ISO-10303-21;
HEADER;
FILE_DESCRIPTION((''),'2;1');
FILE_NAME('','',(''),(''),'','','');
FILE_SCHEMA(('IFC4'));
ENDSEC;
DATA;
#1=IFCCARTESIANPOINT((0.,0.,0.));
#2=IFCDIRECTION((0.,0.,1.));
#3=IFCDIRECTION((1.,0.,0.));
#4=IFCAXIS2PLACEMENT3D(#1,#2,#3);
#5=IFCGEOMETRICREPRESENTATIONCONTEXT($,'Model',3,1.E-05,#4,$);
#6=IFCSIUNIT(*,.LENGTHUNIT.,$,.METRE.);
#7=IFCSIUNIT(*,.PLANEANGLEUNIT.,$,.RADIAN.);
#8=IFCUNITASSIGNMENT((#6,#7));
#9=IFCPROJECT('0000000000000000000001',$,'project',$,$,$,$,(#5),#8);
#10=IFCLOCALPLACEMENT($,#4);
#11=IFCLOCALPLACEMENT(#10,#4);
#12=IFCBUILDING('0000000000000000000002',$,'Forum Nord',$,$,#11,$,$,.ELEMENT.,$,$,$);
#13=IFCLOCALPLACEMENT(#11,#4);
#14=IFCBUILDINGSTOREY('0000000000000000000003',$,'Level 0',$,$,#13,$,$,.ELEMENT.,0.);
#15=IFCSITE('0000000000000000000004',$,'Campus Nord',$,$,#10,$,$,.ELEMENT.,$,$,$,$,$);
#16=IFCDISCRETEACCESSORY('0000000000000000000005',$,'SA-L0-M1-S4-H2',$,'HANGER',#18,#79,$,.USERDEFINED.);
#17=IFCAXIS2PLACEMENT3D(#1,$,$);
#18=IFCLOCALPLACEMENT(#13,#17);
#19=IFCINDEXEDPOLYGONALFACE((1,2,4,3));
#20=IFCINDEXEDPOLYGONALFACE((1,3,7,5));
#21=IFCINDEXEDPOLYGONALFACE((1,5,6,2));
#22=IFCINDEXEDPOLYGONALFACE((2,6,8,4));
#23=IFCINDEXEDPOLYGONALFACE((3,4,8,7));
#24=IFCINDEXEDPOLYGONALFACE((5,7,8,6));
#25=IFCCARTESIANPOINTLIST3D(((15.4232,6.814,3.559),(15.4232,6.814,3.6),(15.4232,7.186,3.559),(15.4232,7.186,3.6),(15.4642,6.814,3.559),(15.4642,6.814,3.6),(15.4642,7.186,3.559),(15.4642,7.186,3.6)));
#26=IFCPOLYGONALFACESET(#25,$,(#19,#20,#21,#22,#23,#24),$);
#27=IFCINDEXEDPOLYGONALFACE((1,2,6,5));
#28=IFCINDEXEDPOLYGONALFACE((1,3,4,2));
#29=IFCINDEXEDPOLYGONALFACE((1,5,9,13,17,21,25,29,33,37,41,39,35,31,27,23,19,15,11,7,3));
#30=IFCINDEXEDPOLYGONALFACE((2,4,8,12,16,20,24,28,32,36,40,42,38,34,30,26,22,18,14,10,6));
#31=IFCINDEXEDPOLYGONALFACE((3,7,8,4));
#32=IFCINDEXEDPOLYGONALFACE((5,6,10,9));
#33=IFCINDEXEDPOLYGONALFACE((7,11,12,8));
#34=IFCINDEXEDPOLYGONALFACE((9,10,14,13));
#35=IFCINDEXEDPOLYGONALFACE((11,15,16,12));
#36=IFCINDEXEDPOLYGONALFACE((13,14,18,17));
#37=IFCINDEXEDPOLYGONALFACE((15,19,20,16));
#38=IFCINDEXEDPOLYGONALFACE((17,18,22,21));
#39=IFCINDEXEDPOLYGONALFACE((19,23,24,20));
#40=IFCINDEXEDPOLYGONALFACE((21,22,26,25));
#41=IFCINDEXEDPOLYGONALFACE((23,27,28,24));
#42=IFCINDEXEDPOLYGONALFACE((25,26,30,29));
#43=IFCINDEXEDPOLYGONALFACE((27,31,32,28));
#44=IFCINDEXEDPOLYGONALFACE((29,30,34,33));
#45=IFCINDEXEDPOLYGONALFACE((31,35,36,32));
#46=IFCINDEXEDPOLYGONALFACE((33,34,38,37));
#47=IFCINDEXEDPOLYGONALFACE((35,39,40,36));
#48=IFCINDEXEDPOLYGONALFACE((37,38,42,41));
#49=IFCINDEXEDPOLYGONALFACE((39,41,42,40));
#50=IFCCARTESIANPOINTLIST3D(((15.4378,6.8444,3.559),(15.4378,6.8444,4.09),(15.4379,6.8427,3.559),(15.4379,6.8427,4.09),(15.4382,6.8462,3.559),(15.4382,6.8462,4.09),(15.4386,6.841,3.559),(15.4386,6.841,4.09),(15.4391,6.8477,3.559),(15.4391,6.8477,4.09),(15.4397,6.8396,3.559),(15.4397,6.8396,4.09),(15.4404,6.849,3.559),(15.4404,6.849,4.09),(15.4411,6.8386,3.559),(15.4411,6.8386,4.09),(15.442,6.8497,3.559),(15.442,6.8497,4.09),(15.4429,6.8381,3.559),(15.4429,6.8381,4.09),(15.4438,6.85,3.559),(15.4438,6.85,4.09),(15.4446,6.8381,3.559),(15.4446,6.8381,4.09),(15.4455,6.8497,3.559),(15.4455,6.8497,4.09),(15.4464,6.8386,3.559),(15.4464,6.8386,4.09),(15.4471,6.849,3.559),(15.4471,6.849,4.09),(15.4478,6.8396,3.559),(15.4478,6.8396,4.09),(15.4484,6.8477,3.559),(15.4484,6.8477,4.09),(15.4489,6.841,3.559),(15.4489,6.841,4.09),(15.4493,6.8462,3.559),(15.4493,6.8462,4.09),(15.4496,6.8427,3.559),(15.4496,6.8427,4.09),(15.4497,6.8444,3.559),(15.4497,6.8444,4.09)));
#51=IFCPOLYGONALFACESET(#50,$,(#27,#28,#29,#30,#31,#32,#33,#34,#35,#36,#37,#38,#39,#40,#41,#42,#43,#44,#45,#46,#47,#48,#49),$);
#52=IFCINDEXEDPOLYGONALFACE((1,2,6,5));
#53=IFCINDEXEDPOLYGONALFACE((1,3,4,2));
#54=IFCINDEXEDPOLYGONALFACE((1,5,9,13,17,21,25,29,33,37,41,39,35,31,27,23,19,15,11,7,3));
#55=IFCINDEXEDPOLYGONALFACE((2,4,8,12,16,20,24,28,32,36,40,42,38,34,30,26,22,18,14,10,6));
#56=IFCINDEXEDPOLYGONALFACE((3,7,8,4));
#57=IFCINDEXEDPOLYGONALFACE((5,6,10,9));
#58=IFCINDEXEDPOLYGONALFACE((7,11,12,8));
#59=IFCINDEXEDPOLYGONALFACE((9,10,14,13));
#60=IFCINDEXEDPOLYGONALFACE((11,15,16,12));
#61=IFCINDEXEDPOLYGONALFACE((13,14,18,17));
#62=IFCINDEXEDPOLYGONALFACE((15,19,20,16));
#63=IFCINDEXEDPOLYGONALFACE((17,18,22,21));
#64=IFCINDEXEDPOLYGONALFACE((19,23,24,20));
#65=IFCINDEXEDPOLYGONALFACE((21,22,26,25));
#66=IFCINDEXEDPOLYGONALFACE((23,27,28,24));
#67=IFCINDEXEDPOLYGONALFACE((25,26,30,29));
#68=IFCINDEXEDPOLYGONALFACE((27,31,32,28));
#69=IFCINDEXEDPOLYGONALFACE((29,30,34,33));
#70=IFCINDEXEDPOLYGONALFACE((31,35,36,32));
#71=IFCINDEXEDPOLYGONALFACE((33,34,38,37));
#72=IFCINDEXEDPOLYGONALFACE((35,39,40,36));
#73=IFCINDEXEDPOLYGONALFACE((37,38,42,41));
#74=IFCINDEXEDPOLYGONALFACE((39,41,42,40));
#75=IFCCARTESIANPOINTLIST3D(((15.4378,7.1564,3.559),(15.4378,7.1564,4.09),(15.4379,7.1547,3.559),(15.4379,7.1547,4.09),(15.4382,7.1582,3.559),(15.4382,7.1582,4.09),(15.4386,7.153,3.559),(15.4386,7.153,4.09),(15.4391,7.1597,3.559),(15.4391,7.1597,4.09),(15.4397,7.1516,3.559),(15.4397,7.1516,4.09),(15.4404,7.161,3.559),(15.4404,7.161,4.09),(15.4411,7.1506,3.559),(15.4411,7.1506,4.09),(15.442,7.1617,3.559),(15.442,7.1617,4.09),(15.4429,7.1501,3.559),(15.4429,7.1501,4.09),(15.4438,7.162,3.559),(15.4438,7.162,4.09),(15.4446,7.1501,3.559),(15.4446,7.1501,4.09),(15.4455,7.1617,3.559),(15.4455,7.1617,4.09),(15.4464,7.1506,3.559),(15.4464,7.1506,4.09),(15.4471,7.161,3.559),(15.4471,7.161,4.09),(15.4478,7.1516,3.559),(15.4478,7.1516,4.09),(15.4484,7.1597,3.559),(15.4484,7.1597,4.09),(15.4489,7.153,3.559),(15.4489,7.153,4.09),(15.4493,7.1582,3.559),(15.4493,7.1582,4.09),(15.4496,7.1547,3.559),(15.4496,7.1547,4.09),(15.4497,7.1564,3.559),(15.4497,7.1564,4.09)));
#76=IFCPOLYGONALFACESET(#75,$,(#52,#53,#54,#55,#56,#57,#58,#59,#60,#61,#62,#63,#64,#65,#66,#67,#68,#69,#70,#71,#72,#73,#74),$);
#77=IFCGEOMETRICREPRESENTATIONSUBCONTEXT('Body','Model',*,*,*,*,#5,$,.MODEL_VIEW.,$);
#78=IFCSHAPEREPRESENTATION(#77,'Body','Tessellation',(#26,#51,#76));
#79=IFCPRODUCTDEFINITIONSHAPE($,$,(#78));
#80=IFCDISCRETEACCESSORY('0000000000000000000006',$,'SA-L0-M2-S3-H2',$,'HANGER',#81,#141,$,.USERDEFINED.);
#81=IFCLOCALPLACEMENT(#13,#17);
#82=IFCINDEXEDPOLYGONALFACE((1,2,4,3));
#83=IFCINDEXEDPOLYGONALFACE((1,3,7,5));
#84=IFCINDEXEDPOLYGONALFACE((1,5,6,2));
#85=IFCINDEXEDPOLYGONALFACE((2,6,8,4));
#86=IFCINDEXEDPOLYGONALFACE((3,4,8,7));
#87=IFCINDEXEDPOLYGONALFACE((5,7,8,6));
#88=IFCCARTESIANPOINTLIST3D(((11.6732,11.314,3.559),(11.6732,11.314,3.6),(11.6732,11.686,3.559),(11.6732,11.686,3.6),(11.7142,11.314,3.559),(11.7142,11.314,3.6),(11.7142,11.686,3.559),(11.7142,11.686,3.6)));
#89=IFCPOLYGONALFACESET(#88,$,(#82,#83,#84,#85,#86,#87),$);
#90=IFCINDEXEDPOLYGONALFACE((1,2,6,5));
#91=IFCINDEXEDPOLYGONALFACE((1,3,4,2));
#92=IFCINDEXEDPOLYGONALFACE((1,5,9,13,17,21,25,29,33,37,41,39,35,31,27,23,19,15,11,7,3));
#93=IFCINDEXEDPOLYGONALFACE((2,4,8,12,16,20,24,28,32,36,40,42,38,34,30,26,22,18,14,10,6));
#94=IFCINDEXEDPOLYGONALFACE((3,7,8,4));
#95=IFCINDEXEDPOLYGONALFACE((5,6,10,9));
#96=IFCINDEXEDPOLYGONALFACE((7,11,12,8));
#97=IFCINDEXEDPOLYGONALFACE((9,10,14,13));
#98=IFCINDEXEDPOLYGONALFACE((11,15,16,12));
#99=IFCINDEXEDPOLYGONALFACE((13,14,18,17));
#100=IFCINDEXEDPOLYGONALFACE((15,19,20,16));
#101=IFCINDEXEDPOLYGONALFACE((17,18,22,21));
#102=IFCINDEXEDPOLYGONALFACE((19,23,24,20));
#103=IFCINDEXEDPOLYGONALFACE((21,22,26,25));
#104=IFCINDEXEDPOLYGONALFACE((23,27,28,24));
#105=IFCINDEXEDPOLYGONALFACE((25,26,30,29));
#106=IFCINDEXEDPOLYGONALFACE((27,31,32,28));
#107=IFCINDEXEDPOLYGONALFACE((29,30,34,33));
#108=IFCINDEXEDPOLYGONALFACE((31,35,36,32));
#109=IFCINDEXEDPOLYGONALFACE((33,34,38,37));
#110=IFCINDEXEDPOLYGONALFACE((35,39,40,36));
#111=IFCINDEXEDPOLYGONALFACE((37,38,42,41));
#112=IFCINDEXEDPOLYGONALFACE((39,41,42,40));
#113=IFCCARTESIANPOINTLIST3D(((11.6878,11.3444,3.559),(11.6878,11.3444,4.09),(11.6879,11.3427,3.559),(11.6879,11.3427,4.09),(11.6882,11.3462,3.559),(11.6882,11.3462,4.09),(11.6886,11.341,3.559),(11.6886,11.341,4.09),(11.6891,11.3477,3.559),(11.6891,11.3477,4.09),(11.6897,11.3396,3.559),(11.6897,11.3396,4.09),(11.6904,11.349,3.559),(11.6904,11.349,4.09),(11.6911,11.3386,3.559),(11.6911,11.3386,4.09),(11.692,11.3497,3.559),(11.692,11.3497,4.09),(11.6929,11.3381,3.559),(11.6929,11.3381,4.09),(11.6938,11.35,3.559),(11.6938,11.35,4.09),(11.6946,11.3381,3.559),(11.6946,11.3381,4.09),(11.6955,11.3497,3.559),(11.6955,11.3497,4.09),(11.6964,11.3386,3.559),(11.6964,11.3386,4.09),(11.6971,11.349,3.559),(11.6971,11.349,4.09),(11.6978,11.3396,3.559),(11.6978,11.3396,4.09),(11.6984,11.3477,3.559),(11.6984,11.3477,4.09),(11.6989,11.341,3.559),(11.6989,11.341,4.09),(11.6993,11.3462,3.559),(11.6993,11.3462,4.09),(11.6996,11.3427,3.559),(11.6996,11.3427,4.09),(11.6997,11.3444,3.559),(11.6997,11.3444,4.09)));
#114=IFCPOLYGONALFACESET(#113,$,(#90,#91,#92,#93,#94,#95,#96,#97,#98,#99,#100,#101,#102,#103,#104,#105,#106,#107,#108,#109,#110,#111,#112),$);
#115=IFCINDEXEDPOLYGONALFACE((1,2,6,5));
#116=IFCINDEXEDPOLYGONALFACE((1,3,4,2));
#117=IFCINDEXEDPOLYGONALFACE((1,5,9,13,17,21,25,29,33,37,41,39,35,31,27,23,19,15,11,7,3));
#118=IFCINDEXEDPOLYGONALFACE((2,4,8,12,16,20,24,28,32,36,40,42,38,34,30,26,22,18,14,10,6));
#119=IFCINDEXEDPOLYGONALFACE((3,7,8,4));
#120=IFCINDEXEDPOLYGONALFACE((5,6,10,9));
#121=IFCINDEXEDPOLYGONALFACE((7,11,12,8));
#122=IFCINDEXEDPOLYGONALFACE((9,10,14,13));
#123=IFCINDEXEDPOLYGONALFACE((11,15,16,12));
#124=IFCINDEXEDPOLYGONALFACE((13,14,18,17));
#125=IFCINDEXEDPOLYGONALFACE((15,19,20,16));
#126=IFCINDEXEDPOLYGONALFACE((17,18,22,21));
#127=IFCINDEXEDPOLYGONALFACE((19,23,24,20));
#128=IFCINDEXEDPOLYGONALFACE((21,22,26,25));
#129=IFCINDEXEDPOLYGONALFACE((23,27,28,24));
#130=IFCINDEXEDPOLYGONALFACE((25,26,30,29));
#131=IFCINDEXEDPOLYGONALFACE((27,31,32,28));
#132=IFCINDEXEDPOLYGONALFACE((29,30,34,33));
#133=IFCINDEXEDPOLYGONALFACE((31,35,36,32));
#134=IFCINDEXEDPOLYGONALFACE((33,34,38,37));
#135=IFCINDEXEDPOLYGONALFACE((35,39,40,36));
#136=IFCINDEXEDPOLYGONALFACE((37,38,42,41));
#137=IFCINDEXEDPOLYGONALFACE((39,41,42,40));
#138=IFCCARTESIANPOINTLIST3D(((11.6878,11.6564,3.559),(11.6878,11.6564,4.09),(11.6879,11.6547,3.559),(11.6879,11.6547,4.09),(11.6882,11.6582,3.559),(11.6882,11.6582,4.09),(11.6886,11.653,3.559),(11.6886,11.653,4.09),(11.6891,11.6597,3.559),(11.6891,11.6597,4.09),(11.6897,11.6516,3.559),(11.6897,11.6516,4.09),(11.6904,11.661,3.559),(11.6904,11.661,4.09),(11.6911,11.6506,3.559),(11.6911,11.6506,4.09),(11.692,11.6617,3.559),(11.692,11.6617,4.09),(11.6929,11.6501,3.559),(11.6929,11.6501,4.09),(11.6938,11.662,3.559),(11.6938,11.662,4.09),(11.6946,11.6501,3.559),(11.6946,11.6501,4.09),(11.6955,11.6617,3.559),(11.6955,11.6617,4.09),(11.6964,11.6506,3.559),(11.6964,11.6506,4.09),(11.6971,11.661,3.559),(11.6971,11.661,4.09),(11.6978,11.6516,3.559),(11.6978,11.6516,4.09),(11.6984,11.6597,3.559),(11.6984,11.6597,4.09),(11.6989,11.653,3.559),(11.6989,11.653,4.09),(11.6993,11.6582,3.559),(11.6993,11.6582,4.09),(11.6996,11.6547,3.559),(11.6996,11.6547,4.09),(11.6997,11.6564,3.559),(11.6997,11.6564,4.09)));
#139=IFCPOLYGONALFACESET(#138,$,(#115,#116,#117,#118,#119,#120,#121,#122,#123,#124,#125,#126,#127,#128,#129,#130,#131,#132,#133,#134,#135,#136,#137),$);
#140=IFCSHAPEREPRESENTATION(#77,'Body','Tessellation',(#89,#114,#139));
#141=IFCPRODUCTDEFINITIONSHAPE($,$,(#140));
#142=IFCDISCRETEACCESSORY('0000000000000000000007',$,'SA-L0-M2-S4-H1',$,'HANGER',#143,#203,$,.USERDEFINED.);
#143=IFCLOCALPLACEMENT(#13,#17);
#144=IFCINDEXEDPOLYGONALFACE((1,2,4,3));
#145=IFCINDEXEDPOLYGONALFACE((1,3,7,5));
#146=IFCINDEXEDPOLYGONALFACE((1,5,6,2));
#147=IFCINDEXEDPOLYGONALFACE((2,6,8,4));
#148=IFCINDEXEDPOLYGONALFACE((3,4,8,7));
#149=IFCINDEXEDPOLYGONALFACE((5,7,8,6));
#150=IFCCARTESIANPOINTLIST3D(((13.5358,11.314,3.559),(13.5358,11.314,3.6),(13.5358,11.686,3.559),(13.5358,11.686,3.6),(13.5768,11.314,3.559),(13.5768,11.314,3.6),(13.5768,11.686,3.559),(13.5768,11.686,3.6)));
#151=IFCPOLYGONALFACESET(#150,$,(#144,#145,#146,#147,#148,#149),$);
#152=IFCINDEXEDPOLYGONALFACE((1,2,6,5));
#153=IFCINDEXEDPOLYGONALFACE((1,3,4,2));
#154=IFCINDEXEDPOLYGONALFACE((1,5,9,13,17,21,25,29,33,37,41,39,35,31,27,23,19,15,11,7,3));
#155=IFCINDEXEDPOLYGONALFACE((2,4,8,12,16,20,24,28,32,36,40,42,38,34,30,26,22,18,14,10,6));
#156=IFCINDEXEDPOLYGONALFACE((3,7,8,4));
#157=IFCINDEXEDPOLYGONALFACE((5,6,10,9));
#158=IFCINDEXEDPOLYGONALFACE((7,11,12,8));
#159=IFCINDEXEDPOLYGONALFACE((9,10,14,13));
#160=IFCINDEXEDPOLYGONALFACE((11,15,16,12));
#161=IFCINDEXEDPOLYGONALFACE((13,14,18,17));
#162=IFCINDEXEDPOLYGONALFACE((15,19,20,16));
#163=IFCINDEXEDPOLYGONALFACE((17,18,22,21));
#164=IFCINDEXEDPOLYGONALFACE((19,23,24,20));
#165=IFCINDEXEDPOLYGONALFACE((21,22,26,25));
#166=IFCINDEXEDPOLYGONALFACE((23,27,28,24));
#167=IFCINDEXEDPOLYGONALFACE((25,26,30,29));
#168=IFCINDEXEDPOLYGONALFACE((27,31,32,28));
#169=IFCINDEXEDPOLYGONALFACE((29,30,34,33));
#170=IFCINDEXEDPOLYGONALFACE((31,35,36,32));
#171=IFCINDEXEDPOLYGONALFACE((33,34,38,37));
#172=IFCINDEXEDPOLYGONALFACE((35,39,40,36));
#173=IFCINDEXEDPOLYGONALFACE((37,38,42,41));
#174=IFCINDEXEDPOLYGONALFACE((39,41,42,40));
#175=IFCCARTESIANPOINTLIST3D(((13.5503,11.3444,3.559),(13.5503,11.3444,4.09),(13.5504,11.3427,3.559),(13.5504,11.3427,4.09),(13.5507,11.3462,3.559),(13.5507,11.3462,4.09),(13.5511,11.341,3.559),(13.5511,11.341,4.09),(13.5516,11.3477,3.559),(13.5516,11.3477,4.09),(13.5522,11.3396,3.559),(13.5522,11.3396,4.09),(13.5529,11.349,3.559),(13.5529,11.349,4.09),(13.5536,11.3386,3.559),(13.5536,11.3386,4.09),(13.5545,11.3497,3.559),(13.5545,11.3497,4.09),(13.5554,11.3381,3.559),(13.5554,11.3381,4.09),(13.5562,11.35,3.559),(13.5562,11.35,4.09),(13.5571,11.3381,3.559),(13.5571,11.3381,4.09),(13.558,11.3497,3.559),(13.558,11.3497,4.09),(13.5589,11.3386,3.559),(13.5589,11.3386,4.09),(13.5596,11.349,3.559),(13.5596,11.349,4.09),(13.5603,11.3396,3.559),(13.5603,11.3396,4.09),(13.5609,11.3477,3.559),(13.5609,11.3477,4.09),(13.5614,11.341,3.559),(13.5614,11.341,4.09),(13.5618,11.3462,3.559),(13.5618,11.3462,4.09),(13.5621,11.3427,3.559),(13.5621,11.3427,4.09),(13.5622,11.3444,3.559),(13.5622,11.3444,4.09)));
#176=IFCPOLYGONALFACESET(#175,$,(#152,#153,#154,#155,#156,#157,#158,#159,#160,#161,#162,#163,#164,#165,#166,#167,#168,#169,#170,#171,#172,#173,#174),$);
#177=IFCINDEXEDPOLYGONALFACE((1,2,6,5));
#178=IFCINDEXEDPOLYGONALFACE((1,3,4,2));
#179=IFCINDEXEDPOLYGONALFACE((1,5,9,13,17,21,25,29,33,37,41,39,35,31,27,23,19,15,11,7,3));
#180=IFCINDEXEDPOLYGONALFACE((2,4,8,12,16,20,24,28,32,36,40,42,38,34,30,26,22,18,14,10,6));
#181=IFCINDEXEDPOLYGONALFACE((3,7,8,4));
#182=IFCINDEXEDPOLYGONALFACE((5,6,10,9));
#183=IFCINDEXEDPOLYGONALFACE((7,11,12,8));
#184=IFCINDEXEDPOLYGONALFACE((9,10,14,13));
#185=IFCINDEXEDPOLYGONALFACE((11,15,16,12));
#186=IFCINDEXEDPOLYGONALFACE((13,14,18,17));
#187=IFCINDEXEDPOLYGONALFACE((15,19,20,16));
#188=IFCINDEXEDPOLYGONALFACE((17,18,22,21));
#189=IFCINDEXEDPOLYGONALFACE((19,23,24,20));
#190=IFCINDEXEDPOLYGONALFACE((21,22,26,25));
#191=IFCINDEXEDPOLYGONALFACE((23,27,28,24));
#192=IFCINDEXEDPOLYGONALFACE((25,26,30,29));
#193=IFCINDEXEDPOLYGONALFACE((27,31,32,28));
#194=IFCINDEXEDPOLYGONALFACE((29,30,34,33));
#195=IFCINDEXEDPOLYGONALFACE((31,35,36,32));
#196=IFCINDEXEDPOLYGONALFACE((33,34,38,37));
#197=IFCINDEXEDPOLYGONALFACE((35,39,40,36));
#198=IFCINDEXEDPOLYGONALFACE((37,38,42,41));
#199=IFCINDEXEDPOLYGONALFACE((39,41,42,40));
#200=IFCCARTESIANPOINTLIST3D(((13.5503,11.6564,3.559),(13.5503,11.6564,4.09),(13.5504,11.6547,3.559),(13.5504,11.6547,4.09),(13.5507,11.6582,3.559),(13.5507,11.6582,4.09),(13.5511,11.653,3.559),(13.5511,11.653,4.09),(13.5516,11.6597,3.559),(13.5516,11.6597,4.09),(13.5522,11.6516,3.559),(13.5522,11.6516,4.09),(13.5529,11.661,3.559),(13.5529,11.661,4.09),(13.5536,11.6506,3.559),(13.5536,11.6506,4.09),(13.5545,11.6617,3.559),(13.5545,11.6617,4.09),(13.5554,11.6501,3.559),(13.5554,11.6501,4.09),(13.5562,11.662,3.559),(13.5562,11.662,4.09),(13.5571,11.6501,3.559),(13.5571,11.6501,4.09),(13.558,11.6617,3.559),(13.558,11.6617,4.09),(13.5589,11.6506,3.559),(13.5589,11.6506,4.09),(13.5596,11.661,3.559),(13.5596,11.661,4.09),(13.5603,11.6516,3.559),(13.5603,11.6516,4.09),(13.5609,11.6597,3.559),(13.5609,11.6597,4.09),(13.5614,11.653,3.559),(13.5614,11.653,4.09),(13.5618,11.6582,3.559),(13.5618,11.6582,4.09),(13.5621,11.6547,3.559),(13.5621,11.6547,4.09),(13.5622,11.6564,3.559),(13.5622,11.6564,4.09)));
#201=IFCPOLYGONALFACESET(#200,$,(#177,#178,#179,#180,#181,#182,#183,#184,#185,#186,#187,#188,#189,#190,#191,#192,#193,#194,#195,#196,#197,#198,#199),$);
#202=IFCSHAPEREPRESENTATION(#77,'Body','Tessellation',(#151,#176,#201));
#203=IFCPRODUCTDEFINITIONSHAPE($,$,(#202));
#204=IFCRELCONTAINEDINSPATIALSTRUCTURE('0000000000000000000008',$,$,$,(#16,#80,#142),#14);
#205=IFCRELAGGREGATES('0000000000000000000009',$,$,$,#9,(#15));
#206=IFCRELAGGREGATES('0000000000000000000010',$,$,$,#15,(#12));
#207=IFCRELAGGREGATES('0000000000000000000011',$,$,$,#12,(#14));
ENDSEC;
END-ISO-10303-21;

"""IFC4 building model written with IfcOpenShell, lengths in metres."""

from ifc_helpers import new_model, si_unit, frame, frame_2d, origin_with_axes, origin_2d_with_axis, place, context, subcontext, project, spatial, rectangle, circle, extrude, element, save


model = new_model("IFC4")

# Units and contexts
model_context = context("Model", 3, precision=1e-05, world=origin_with_axes())
body_context = subcontext(model_context, "Body", "Model", "MODEL_VIEW")
ifc_project = project(units=[si_unit("LENGTHUNIT", "METRE"), si_unit("PLANEANGLEUNIT", "RADIAN")], contexts=[model_context])

# Site, building, storey
site_placement = place(None, origin_with_axes())
site = spatial("IfcSite", under=ifc_project, at=site_placement, Name="Campus Nord", CompositionType="ELEMENT")
building_placement = place(site_placement, origin_with_axes())
building = spatial("IfcBuilding", under=site, at=building_placement, Name="Forum Nord", CompositionType="ELEMENT")
storey_placement = place(building_placement, origin_with_axes())
storey = spatial("IfcBuildingStorey", under=building, at=storey_placement, Name="Level 0", CompositionType="ELEMENT", Elevation=0.0)

# Discrete accessories
for number, where, z_axis, x_axis, name in (
    (1, (15.4437, 7.0, 3.6), (0.0, 0.0, 1.0), (0.0, 1.0, 0.0), "SA-L0-M1-S4-H2"),
    (2, (11.6937, 11.5, 3.6), (0.0, 0.0, 1.0), (0.0, 1.0, 0.0), "SA-L0-M2-S3-H2"),
    (3, (13.5563, 11.5, 3.6), (0.0, 0.0, 1.0), (0.0, 1.0, 0.0), "SA-L0-M2-S4-H1"),
):
    element("IfcDiscreteAccessory", number, at=place(storey_placement, frame(where, z_axis=z_axis, x_axis=x_axis)), inside=storey, Name=name, ObjectType="HANGER", PredefinedType="USERDEFINED", context=body_context, shape_type="SweptSolid", body=[
        extrude(rectangle(XDim=0.372, YDim=0.041, at=origin_2d_with_axis()), frame((0.0, 0.0, -0.041), z_axis=(0.0, 0.0, 1.0), x_axis=(1.0, 0.0, 0.0)), (0.0, 0.0, 1.0), 0.041),
        extrude(circle(Radius=0.006, at=frame_2d((-0.156, 0.0), x_axis=(1.0, 0.0))), frame((0.0, 0.0, -0.041), z_axis=(0.0, 0.0, 1.0), x_axis=(1.0, 0.0, 0.0)), (0.0, 0.0, 1.0), 0.531),
        extrude(circle(Radius=0.006, at=frame_2d((0.156, 0.0), x_axis=(1.0, 0.0))), frame((0.0, 0.0, -0.041), z_axis=(0.0, 0.0, 1.0), x_axis=(1.0, 0.0, 0.0)), (0.0, 0.0, 1.0), 0.531),
    ])

save(model, "model.ifc")
